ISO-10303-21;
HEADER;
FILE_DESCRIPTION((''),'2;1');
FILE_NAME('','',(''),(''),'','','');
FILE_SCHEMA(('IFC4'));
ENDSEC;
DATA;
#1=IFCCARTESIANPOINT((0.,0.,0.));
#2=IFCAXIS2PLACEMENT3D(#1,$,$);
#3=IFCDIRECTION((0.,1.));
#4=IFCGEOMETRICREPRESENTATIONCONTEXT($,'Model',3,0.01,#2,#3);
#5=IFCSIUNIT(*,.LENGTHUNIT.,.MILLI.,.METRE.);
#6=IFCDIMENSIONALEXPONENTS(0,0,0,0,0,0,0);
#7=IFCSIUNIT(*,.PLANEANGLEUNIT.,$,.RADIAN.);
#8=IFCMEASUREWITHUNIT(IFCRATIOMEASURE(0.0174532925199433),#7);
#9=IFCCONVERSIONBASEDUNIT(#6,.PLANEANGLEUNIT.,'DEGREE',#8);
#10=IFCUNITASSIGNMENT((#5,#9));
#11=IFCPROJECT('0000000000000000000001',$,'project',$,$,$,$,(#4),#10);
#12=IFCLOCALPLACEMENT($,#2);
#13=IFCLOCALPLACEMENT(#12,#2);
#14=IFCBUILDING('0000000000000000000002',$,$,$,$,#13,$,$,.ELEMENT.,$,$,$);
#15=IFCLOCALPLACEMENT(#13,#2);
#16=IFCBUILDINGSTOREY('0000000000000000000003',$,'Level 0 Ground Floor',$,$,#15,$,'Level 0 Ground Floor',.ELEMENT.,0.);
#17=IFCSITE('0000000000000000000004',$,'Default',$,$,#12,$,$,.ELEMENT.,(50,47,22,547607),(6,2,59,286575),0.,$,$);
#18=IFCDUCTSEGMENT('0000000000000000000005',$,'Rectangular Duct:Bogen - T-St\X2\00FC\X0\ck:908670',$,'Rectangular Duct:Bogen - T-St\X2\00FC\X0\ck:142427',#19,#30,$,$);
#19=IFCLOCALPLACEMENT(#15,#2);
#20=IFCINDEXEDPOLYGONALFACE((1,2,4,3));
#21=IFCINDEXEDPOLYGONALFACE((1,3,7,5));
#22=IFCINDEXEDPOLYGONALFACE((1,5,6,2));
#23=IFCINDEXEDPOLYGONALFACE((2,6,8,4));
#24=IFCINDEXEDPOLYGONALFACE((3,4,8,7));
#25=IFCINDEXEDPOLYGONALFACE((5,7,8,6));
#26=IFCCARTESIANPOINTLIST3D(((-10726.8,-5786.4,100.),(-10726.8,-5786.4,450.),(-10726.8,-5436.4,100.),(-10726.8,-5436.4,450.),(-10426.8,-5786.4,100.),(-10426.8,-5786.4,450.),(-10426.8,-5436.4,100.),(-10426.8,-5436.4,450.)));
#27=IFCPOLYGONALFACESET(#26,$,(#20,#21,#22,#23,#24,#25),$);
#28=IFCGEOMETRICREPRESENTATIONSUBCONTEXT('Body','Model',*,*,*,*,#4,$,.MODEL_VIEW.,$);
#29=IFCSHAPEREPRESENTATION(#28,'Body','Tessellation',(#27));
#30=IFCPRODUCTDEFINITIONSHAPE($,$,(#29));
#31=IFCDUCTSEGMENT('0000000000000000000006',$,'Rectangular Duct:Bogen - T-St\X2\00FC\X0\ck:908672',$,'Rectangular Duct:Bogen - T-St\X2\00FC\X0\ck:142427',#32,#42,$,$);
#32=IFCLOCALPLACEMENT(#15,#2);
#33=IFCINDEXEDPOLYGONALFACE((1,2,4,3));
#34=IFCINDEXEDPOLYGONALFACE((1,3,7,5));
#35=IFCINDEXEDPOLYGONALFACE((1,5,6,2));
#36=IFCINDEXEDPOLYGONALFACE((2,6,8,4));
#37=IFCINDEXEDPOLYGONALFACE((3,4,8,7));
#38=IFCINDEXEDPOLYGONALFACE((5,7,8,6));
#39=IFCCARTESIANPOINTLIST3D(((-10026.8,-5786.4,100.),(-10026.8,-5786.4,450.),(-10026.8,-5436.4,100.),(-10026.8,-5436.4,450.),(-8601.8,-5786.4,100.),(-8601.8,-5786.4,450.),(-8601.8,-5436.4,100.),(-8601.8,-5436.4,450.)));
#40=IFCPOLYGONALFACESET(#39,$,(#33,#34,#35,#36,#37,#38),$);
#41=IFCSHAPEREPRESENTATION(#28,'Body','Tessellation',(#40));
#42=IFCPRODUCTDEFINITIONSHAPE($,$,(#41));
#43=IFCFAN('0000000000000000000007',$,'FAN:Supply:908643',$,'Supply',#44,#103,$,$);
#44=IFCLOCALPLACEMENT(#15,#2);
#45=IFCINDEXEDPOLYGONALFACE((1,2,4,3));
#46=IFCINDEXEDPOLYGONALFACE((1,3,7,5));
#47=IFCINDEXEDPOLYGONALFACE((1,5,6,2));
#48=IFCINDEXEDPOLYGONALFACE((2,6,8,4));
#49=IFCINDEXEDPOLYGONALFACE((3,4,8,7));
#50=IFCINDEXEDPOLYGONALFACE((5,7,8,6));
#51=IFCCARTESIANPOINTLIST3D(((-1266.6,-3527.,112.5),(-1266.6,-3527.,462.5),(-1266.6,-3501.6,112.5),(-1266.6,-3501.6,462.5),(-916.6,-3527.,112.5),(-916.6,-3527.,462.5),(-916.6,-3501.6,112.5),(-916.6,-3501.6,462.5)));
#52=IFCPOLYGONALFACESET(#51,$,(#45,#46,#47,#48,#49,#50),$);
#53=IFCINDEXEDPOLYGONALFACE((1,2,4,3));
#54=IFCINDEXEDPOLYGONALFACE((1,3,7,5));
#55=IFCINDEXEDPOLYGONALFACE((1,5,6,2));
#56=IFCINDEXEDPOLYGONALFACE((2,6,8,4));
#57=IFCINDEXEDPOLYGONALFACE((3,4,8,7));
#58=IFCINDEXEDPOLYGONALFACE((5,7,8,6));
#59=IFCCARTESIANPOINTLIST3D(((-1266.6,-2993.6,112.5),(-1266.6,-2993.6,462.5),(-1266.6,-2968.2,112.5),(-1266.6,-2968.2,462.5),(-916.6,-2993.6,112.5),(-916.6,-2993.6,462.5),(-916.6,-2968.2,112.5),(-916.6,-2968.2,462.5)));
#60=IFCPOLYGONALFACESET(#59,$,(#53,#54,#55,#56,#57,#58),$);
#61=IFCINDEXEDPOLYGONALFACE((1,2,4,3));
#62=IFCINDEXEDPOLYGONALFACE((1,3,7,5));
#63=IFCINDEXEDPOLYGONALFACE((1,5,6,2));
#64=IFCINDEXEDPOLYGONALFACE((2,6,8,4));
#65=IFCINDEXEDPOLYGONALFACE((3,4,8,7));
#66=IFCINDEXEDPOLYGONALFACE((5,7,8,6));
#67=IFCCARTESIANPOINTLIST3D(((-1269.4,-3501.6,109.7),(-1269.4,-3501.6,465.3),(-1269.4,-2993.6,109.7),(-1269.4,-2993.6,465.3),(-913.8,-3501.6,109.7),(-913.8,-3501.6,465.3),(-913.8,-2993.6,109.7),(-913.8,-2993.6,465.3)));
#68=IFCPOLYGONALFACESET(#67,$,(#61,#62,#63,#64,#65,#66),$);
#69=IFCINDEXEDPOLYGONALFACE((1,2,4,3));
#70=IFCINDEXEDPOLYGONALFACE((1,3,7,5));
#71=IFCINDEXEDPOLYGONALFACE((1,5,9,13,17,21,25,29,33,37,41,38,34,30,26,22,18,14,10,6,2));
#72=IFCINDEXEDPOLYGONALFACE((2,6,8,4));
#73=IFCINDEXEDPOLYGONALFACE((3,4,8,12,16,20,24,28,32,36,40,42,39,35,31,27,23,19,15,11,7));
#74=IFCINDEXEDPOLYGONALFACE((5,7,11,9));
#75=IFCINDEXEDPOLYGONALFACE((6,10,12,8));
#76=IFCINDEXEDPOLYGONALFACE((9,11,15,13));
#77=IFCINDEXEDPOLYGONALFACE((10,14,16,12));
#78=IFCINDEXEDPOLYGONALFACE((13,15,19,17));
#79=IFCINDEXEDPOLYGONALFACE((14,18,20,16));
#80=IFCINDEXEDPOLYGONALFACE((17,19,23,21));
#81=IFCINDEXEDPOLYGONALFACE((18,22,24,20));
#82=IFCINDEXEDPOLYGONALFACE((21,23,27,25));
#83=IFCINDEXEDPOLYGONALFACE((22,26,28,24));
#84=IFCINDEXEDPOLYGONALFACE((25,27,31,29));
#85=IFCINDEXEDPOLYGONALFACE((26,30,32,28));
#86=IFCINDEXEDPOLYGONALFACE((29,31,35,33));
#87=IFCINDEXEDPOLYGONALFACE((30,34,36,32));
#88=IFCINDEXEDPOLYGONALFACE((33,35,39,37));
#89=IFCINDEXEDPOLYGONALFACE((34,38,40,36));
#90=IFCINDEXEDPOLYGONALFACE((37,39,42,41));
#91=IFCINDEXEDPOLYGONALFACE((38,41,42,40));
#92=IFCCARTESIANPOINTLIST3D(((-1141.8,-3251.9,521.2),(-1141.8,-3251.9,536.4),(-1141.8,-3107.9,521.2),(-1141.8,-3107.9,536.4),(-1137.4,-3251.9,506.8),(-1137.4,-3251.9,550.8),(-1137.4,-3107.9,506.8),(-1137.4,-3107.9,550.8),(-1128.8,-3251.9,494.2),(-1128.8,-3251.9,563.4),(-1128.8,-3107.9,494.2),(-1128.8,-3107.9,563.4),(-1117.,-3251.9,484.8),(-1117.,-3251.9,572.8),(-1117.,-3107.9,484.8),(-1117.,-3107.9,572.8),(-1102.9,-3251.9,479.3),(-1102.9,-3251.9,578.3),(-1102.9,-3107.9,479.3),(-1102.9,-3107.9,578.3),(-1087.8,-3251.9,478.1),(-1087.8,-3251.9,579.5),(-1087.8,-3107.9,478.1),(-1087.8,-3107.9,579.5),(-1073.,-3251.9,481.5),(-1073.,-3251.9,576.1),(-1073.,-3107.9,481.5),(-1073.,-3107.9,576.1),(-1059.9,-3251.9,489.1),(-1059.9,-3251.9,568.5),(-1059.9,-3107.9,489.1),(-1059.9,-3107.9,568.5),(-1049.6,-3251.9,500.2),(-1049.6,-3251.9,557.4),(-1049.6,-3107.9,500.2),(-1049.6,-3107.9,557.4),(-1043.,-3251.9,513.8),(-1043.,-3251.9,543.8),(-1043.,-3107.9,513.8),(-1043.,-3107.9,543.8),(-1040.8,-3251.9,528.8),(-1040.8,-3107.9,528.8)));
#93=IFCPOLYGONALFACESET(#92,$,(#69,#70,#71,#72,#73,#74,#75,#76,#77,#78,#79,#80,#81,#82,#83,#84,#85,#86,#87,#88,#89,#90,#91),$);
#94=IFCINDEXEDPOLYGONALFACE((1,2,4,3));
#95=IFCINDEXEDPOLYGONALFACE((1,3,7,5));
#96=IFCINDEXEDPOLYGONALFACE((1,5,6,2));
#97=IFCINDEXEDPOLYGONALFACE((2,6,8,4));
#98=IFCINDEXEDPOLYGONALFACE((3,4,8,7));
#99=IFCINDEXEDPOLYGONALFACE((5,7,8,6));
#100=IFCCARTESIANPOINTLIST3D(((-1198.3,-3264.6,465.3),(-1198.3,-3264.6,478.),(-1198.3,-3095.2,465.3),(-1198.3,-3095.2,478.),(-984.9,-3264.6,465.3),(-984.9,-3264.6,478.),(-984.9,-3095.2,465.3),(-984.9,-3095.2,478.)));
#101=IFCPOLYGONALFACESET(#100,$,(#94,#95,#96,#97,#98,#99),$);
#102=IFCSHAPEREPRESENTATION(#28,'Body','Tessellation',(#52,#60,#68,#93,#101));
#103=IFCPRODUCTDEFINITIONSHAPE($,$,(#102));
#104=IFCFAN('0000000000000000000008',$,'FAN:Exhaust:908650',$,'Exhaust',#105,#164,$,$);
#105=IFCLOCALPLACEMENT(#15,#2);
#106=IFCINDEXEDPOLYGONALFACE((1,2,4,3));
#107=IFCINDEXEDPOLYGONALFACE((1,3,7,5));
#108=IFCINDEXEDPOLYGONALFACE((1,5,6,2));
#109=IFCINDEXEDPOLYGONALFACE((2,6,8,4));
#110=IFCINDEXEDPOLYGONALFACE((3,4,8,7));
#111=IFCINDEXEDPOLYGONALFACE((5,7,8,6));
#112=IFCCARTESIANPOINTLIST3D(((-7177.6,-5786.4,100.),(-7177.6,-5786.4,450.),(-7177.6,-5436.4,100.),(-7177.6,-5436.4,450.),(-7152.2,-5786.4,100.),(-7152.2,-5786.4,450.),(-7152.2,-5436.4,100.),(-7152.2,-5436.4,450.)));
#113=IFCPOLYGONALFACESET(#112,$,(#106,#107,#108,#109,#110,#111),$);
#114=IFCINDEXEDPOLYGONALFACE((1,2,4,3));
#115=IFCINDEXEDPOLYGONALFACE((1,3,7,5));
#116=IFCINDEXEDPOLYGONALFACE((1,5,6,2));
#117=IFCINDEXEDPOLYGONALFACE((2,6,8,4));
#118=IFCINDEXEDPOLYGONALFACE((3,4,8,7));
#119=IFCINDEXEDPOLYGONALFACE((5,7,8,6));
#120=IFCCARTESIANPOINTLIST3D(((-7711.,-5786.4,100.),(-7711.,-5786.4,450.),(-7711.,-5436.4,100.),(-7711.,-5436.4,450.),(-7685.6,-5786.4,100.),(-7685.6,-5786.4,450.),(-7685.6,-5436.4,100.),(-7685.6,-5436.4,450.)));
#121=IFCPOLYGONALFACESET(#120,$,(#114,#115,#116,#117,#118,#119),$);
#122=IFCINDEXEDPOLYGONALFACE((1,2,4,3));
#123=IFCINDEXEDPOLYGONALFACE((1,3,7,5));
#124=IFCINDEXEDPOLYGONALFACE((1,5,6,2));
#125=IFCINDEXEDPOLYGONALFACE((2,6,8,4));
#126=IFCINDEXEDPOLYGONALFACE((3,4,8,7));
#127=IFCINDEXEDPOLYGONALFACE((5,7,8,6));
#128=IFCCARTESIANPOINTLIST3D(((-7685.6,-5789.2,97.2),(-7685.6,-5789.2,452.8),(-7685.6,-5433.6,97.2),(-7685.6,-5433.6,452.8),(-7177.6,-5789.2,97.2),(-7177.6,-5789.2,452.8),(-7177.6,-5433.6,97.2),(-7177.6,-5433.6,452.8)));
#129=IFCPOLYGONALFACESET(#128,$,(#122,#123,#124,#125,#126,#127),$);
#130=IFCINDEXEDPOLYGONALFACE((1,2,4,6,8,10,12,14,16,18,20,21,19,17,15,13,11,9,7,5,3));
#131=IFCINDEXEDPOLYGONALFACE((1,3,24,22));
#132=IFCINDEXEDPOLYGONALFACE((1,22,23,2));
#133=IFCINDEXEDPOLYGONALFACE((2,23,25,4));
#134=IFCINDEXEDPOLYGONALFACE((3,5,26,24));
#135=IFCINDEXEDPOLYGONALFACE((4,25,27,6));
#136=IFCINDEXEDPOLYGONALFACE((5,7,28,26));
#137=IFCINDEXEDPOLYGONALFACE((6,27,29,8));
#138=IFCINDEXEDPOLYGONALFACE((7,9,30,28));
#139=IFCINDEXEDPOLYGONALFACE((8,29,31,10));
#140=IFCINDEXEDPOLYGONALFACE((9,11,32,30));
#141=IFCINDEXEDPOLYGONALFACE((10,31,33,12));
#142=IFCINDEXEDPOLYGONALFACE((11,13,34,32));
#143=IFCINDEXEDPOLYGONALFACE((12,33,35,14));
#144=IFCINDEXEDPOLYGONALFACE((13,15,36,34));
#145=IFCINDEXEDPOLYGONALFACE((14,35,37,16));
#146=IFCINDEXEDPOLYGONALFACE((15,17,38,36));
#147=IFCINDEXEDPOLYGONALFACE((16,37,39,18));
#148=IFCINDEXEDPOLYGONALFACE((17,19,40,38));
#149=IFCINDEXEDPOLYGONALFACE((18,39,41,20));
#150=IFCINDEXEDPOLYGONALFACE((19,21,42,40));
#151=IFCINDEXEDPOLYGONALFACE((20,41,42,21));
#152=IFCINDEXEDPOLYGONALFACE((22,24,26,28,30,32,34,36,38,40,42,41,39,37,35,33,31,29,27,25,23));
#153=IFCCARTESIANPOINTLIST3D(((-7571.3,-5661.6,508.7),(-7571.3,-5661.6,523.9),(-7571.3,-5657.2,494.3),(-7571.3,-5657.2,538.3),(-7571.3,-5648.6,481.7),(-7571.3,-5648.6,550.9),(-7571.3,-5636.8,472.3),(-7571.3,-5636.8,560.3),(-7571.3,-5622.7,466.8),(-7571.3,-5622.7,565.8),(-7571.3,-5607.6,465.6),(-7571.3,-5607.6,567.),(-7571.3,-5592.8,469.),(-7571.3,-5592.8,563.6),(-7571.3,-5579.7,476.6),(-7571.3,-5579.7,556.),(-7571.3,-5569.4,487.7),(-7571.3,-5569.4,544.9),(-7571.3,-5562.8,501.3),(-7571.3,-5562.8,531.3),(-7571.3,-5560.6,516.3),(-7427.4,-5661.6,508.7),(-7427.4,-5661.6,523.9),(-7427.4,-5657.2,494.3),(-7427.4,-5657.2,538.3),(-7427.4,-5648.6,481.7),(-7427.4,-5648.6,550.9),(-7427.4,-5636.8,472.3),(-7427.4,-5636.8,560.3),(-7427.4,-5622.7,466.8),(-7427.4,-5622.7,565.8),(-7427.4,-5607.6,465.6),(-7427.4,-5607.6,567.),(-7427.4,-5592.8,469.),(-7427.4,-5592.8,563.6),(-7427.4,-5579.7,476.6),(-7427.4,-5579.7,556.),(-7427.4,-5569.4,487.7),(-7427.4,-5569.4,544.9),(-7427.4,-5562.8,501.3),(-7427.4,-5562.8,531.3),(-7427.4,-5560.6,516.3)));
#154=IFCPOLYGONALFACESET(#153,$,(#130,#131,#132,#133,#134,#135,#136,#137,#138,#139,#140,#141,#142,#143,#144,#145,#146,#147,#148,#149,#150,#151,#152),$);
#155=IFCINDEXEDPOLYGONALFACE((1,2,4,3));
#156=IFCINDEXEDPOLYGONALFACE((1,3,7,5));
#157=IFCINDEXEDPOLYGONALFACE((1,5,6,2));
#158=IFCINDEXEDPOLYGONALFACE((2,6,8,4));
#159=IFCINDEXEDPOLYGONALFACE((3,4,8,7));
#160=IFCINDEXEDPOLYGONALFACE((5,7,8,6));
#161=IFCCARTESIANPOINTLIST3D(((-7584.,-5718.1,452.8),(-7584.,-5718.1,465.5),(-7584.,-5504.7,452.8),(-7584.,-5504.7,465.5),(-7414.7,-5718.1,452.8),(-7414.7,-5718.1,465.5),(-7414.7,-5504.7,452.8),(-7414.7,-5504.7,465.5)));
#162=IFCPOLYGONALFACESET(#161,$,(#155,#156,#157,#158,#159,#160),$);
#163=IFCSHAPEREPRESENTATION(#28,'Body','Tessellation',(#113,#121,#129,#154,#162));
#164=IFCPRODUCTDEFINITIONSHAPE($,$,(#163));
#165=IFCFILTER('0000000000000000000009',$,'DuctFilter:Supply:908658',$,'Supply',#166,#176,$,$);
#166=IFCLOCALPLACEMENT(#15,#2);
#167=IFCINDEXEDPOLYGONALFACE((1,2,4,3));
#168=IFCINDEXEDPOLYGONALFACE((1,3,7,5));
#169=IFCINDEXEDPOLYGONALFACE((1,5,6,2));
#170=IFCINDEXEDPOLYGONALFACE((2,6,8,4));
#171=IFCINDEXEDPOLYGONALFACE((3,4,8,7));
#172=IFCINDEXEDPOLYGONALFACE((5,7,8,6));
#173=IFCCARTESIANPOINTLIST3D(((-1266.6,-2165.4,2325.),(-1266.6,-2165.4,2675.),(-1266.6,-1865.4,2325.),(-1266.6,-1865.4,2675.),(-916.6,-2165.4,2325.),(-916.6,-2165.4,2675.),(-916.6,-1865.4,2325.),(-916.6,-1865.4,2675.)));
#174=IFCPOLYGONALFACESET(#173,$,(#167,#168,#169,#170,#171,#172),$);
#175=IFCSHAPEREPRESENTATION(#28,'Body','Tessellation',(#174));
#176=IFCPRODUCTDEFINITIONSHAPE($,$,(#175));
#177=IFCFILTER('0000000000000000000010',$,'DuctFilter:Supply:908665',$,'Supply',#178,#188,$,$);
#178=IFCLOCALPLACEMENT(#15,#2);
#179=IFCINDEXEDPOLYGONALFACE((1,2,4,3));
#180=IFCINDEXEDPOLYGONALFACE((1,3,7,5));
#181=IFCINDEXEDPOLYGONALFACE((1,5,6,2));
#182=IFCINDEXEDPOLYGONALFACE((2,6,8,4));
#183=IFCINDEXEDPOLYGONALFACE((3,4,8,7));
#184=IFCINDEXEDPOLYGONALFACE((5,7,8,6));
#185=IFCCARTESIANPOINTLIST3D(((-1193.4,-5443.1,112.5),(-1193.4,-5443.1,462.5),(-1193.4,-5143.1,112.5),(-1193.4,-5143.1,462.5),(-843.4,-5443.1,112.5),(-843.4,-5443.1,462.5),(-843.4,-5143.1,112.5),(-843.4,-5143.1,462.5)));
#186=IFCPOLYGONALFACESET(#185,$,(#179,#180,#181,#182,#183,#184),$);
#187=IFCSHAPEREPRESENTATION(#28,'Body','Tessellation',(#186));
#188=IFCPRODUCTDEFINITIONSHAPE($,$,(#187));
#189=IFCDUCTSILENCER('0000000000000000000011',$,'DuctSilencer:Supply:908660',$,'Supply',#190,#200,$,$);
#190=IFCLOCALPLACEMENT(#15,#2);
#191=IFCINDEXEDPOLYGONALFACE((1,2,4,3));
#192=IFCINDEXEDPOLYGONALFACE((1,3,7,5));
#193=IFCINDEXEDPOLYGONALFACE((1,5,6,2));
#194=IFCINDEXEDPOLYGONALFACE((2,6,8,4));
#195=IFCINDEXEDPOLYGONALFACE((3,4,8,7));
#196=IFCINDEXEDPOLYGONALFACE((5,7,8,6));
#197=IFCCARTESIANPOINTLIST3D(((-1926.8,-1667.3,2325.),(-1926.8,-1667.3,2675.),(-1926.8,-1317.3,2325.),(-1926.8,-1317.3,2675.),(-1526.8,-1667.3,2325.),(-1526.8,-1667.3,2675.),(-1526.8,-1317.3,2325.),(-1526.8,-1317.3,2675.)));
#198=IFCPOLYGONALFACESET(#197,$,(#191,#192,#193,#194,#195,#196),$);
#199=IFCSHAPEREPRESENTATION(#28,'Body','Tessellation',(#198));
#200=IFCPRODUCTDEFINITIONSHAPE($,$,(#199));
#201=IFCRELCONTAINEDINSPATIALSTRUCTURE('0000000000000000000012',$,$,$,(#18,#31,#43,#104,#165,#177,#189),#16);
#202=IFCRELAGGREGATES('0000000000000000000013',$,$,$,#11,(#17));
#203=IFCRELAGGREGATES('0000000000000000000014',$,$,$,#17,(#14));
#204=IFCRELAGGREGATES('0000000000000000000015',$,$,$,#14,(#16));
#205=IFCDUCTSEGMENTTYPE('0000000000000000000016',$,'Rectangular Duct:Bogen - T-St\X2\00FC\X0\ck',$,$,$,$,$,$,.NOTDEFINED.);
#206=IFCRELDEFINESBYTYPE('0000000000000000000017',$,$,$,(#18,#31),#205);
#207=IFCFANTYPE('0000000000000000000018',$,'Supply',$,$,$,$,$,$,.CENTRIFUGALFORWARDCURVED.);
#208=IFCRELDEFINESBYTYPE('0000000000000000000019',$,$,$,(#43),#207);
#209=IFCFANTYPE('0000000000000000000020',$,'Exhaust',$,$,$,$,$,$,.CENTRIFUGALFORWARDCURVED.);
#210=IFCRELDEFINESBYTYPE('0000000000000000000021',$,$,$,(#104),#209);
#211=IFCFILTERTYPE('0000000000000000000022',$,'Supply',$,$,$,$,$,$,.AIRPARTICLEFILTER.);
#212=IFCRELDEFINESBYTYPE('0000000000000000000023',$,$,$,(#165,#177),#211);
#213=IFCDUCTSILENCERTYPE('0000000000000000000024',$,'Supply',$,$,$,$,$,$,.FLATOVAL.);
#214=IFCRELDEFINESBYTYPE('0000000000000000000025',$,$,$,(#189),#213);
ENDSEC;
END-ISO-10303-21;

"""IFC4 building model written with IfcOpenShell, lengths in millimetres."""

from ifc_helpers import new_model, entity, si_unit, converted_unit, direction, frame, frame_2d, origin, origin_2d_with_axis, place, context, subcontext, project, spatial, rectangle, circle, extrude, source, transform, mapped, type_object, type_shapes, element, save


model = new_model("IFC4")

# Units and contexts
model_context = context("Model", 3, precision=0.01, world=origin(), true_north=direction((0.0, 1.0)))
body_context = subcontext(model_context, "Body", "Model", "MODEL_VIEW")
ifc_project = project(units=[si_unit("LENGTHUNIT", "METRE", prefix="MILLI"), converted_unit("PLANEANGLEUNIT", "DEGREE", entity("IfcRatioMeasure", 0.0174532925199433), si_unit("PLANEANGLEUNIT", "RADIAN"), dimensions=[0, 0, 0, 0, 0, 0, 0])], contexts=[model_context])

# Site, building, storey
site_placement = place(None, origin())
site = spatial("IfcSite", under=ifc_project, at=site_placement, Name="Default", CompositionType="ELEMENT", RefLatitude=(50, 47, 22, 547607), RefLongitude=(6, 2, 59, 286575), RefElevation=0.0)
building_placement = place(site_placement, origin())
building = spatial("IfcBuilding", under=site, at=building_placement, CompositionType="ELEMENT")
storey_placement = place(building_placement, origin())
storey = spatial("IfcBuildingStorey", under=building, at=storey_placement, Name="Level 0 Ground Floor", LongName="Level 0 Ground Floor", CompositionType="ELEMENT", Elevation=0.0)

# Duct segments
duct_segment_type = type_object("IfcDuctSegmentType", Name="Rectangular Duct:Bogen - T-Stück", PredefinedType="NOTDEFINED")
duct_segment_1_placement = place(storey_placement, frame((-10726.8, -5786.4, 100.0)))
element("IfcDuctSegment", 1, at=duct_segment_1_placement, inside=storey, type_object=duct_segment_type, Name="Rectangular Duct:Bogen - T-Stück:908670", ObjectType="Rectangular Duct:Bogen - T-Stück:142427", context=body_context, shape_type="SweptSolid", body=[
    extrude(rectangle(XDim=300.0, YDim=350.0, at=frame_2d((0.0, 0.0), x_axis=(1.0, 0.0))), frame((150.0, 175.0, 0.0)), (0.0, 0.0, 1.0), 350.0),
])
duct_segment_2_placement = place(storey_placement, frame((-10026.8, -5786.4, 100.0)))
element("IfcDuctSegment", 2, at=duct_segment_2_placement, inside=storey, type_object=duct_segment_type, Name="Rectangular Duct:Bogen - T-Stück:908672", ObjectType="Rectangular Duct:Bogen - T-Stück:142427", context=body_context, shape_type="SweptSolid", body=[
    extrude(rectangle(XDim=1425.0, YDim=350.0, at=frame_2d((0.0, 0.0), x_axis=(1.0, 0.0))), frame((712.5, 175.0, 0.0)), (0.0, 0.0, 1.0), 350.0),
])

# Fans
fan_type_1 = type_object("IfcFanType", Name="Supply", PredefinedType="CENTRIFUGALFORWARDCURVED")
shared_shape_1 = source(origin(), body_context, "Body", "SweptSolid", [
    extrude(rectangle(XDim=350.0, YDim=25.4, at=origin_2d_with_axis()), frame((0.0, -520.7, 2.8), z_axis=(0.0, 0.0, 1.0), x_axis=(-1.0, 0.0, 0.0)), (0.0, 0.0, 1.0), 350.0),
    extrude(rectangle(XDim=350.0, YDim=25.4, at=frame_2d((0.0, 0.0), x_axis=(1.0, 0.0))), frame((0.0, 12.7, 2.8), z_axis=(0.0, 0.0, 1.0), x_axis=(-1.0, 0.0, 0.0)), (0.0, 0.0, 1.0), 350.0),
    extrude(rectangle(XDim=355.6, YDim=508.0, at=origin_2d_with_axis()), frame((0.0, -254.0, 0.0), z_axis=(0.0, 0.0, 1.0), x_axis=(-1.0, 0.0, 0.0)), (0.0, 0.0, 1.0), 355.6),
    extrude(circle(Radius=50.8, at=frame_2d((0.0, 0.0), x_axis=(1.0, 0.0))), frame((0.0, -258.2, 419.1), z_axis=(0.0, 1.0, 0.0), x_axis=(1.0, 0.0, 0.0)), (0.0, 0.0, 1.0), 143.9),
    extrude(rectangle(XDim=213.4, YDim=169.3, at=origin_2d_with_axis()), frame((0.0, -186.3, 355.6), z_axis=(0.0, 0.0, 1.0), x_axis=(-1.0, 0.0, 0.0)), (0.0, 0.0, 1.0), 12.7),
])
type_shapes(fan_type_1, [shared_shape_1])
fan_1_placement = place(storey_placement, frame((-1091.6, -2993.6, 109.7)))
element("IfcFan", 3, at=fan_1_placement, inside=storey, type_object=fan_type_1, Name="FAN:Supply:908643", ObjectType="Supply", context=body_context, shape_type="MappedRepresentation", body=[
    mapped(shared_shape_1, transform((0.0, 0.0, 0.0), scale=1.0)),
])
fan_type_2 = type_object("IfcFanType", Name="Exhaust", PredefinedType="CENTRIFUGALFORWARDCURVED")
shared_shape_2 = source(origin(), body_context, "Body", "SweptSolid", [
    extrude(rectangle(XDim=350.0, YDim=25.4, at=origin_2d_with_axis()), frame((0.0, -520.7, 2.8), z_axis=(0.0, 0.0, 1.0), x_axis=(-1.0, 0.0, 0.0)), (0.0, 0.0, 1.0), 350.0),
    extrude(rectangle(XDim=350.0, YDim=25.4, at=frame_2d((0.0, 0.0), x_axis=(1.0, 0.0))), frame((0.0, 12.7, 2.8), z_axis=(0.0, 0.0, 1.0), x_axis=(-1.0, 0.0, 0.0)), (0.0, 0.0, 1.0), 350.0),
    extrude(rectangle(XDim=355.6, YDim=508.0, at=origin_2d_with_axis()), frame((0.0, -254.0, 0.0), z_axis=(0.0, 0.0, 1.0), x_axis=(-1.0, 0.0, 0.0)), (0.0, 0.0, 1.0), 355.6),
    extrude(circle(Radius=50.8, at=frame_2d((0.0, 0.0), x_axis=(1.0, 0.0))), frame((0.0, -258.2, 419.1), z_axis=(0.0, 1.0, 0.0), x_axis=(1.0, 0.0, 0.0)), (0.0, 0.0, 1.0), 143.9),
    extrude(rectangle(XDim=213.4, YDim=169.3, at=origin_2d_with_axis()), frame((0.0, -186.3, 355.6), z_axis=(0.0, 0.0, 1.0), x_axis=(-1.0, 0.0, 0.0)), (0.0, 0.0, 1.0), 12.7),
])
type_shapes(fan_type_2, [shared_shape_2])
fan_2_placement = place(storey_placement, frame((-7685.6, -5611.4, 97.2), z_axis=(0.0, 0.0, 1.0), x_axis=(0.0, 1.0, 0.0)))
element("IfcFan", 4, at=fan_2_placement, inside=storey, type_object=fan_type_2, Name="FAN:Exhaust:908650", ObjectType="Exhaust", context=body_context, shape_type="MappedRepresentation", body=[
    mapped(shared_shape_2, transform((0.0, 0.0, 0.0), scale=1.0)),
])

# Filters
filter_type_1 = type_object("IfcFilterType", Name="Supply", PredefinedType="AIRPARTICLEFILTER")
shared_shape_3 = source(origin(), body_context, "Body", "SweptSolid", [
    extrude(rectangle(XDim=300.0, YDim=350.0, at=origin_2d_with_axis()), frame((0.0, 0.0, -175.0), z_axis=(0.0, 0.0, 1.0), x_axis=(-1.0, 0.0, 0.0)), (0.0, 0.0, 1.0), 350.0),
])
type_shapes(filter_type_1, [shared_shape_3])
for number, where, z_axis, x_axis, name in (
    (5, (-1091.6, -2015.4, 2500.0), (0.0, 0.0, 1.0), (0.0, 1.0, 0.0), "DuctFilter:Supply:908658"),
    (6, (-1018.4, -5293.1, 287.5), (0.0, 0.0, 1.0), (0.0, 1.0, 0.0), "DuctFilter:Supply:908665"),
):
    element("IfcFilter", number, at=place(storey_placement, frame(where, z_axis=z_axis, x_axis=x_axis)), inside=storey, type_object=filter_type_1, Name=name, ObjectType="Supply", context=body_context, shape_type="MappedRepresentation", body=[
        mapped(shared_shape_3, transform((0.0, 0.0, 0.0), scale=1.0)),
    ])

# Duct silencer
duct_silencer_type_1 = type_object("IfcDuctSilencerType", Name="Supply", PredefinedType="FLATOVAL")
shared_shape_4 = source(origin(), body_context, "Body", "SweptSolid", [
    extrude(rectangle(XDim=400.0, YDim=350.0, at=frame_2d((0.0, 0.0), x_axis=(1.0, 0.0))), frame((0.0, 0.0, -175.0), z_axis=(0.0, 0.0, 1.0), x_axis=(-1.0, 0.0, 0.0)), (0.0, 0.0, 1.0), 350.0),
])
type_shapes(duct_silencer_type_1, [shared_shape_4])
duct_silencer_1_placement = place(storey_placement, frame((-1726.8, -1492.3, 2500.0)))
element("IfcDuctSilencer", 7, at=duct_silencer_1_placement, inside=storey, type_object=duct_silencer_type_1, Name="DuctSilencer:Supply:908660", ObjectType="Supply", context=body_context, shape_type="MappedRepresentation", body=[
    mapped(shared_shape_4, transform((0.0, 0.0, 0.0), scale=1.0)),
])

save(model, "model.ifc")
